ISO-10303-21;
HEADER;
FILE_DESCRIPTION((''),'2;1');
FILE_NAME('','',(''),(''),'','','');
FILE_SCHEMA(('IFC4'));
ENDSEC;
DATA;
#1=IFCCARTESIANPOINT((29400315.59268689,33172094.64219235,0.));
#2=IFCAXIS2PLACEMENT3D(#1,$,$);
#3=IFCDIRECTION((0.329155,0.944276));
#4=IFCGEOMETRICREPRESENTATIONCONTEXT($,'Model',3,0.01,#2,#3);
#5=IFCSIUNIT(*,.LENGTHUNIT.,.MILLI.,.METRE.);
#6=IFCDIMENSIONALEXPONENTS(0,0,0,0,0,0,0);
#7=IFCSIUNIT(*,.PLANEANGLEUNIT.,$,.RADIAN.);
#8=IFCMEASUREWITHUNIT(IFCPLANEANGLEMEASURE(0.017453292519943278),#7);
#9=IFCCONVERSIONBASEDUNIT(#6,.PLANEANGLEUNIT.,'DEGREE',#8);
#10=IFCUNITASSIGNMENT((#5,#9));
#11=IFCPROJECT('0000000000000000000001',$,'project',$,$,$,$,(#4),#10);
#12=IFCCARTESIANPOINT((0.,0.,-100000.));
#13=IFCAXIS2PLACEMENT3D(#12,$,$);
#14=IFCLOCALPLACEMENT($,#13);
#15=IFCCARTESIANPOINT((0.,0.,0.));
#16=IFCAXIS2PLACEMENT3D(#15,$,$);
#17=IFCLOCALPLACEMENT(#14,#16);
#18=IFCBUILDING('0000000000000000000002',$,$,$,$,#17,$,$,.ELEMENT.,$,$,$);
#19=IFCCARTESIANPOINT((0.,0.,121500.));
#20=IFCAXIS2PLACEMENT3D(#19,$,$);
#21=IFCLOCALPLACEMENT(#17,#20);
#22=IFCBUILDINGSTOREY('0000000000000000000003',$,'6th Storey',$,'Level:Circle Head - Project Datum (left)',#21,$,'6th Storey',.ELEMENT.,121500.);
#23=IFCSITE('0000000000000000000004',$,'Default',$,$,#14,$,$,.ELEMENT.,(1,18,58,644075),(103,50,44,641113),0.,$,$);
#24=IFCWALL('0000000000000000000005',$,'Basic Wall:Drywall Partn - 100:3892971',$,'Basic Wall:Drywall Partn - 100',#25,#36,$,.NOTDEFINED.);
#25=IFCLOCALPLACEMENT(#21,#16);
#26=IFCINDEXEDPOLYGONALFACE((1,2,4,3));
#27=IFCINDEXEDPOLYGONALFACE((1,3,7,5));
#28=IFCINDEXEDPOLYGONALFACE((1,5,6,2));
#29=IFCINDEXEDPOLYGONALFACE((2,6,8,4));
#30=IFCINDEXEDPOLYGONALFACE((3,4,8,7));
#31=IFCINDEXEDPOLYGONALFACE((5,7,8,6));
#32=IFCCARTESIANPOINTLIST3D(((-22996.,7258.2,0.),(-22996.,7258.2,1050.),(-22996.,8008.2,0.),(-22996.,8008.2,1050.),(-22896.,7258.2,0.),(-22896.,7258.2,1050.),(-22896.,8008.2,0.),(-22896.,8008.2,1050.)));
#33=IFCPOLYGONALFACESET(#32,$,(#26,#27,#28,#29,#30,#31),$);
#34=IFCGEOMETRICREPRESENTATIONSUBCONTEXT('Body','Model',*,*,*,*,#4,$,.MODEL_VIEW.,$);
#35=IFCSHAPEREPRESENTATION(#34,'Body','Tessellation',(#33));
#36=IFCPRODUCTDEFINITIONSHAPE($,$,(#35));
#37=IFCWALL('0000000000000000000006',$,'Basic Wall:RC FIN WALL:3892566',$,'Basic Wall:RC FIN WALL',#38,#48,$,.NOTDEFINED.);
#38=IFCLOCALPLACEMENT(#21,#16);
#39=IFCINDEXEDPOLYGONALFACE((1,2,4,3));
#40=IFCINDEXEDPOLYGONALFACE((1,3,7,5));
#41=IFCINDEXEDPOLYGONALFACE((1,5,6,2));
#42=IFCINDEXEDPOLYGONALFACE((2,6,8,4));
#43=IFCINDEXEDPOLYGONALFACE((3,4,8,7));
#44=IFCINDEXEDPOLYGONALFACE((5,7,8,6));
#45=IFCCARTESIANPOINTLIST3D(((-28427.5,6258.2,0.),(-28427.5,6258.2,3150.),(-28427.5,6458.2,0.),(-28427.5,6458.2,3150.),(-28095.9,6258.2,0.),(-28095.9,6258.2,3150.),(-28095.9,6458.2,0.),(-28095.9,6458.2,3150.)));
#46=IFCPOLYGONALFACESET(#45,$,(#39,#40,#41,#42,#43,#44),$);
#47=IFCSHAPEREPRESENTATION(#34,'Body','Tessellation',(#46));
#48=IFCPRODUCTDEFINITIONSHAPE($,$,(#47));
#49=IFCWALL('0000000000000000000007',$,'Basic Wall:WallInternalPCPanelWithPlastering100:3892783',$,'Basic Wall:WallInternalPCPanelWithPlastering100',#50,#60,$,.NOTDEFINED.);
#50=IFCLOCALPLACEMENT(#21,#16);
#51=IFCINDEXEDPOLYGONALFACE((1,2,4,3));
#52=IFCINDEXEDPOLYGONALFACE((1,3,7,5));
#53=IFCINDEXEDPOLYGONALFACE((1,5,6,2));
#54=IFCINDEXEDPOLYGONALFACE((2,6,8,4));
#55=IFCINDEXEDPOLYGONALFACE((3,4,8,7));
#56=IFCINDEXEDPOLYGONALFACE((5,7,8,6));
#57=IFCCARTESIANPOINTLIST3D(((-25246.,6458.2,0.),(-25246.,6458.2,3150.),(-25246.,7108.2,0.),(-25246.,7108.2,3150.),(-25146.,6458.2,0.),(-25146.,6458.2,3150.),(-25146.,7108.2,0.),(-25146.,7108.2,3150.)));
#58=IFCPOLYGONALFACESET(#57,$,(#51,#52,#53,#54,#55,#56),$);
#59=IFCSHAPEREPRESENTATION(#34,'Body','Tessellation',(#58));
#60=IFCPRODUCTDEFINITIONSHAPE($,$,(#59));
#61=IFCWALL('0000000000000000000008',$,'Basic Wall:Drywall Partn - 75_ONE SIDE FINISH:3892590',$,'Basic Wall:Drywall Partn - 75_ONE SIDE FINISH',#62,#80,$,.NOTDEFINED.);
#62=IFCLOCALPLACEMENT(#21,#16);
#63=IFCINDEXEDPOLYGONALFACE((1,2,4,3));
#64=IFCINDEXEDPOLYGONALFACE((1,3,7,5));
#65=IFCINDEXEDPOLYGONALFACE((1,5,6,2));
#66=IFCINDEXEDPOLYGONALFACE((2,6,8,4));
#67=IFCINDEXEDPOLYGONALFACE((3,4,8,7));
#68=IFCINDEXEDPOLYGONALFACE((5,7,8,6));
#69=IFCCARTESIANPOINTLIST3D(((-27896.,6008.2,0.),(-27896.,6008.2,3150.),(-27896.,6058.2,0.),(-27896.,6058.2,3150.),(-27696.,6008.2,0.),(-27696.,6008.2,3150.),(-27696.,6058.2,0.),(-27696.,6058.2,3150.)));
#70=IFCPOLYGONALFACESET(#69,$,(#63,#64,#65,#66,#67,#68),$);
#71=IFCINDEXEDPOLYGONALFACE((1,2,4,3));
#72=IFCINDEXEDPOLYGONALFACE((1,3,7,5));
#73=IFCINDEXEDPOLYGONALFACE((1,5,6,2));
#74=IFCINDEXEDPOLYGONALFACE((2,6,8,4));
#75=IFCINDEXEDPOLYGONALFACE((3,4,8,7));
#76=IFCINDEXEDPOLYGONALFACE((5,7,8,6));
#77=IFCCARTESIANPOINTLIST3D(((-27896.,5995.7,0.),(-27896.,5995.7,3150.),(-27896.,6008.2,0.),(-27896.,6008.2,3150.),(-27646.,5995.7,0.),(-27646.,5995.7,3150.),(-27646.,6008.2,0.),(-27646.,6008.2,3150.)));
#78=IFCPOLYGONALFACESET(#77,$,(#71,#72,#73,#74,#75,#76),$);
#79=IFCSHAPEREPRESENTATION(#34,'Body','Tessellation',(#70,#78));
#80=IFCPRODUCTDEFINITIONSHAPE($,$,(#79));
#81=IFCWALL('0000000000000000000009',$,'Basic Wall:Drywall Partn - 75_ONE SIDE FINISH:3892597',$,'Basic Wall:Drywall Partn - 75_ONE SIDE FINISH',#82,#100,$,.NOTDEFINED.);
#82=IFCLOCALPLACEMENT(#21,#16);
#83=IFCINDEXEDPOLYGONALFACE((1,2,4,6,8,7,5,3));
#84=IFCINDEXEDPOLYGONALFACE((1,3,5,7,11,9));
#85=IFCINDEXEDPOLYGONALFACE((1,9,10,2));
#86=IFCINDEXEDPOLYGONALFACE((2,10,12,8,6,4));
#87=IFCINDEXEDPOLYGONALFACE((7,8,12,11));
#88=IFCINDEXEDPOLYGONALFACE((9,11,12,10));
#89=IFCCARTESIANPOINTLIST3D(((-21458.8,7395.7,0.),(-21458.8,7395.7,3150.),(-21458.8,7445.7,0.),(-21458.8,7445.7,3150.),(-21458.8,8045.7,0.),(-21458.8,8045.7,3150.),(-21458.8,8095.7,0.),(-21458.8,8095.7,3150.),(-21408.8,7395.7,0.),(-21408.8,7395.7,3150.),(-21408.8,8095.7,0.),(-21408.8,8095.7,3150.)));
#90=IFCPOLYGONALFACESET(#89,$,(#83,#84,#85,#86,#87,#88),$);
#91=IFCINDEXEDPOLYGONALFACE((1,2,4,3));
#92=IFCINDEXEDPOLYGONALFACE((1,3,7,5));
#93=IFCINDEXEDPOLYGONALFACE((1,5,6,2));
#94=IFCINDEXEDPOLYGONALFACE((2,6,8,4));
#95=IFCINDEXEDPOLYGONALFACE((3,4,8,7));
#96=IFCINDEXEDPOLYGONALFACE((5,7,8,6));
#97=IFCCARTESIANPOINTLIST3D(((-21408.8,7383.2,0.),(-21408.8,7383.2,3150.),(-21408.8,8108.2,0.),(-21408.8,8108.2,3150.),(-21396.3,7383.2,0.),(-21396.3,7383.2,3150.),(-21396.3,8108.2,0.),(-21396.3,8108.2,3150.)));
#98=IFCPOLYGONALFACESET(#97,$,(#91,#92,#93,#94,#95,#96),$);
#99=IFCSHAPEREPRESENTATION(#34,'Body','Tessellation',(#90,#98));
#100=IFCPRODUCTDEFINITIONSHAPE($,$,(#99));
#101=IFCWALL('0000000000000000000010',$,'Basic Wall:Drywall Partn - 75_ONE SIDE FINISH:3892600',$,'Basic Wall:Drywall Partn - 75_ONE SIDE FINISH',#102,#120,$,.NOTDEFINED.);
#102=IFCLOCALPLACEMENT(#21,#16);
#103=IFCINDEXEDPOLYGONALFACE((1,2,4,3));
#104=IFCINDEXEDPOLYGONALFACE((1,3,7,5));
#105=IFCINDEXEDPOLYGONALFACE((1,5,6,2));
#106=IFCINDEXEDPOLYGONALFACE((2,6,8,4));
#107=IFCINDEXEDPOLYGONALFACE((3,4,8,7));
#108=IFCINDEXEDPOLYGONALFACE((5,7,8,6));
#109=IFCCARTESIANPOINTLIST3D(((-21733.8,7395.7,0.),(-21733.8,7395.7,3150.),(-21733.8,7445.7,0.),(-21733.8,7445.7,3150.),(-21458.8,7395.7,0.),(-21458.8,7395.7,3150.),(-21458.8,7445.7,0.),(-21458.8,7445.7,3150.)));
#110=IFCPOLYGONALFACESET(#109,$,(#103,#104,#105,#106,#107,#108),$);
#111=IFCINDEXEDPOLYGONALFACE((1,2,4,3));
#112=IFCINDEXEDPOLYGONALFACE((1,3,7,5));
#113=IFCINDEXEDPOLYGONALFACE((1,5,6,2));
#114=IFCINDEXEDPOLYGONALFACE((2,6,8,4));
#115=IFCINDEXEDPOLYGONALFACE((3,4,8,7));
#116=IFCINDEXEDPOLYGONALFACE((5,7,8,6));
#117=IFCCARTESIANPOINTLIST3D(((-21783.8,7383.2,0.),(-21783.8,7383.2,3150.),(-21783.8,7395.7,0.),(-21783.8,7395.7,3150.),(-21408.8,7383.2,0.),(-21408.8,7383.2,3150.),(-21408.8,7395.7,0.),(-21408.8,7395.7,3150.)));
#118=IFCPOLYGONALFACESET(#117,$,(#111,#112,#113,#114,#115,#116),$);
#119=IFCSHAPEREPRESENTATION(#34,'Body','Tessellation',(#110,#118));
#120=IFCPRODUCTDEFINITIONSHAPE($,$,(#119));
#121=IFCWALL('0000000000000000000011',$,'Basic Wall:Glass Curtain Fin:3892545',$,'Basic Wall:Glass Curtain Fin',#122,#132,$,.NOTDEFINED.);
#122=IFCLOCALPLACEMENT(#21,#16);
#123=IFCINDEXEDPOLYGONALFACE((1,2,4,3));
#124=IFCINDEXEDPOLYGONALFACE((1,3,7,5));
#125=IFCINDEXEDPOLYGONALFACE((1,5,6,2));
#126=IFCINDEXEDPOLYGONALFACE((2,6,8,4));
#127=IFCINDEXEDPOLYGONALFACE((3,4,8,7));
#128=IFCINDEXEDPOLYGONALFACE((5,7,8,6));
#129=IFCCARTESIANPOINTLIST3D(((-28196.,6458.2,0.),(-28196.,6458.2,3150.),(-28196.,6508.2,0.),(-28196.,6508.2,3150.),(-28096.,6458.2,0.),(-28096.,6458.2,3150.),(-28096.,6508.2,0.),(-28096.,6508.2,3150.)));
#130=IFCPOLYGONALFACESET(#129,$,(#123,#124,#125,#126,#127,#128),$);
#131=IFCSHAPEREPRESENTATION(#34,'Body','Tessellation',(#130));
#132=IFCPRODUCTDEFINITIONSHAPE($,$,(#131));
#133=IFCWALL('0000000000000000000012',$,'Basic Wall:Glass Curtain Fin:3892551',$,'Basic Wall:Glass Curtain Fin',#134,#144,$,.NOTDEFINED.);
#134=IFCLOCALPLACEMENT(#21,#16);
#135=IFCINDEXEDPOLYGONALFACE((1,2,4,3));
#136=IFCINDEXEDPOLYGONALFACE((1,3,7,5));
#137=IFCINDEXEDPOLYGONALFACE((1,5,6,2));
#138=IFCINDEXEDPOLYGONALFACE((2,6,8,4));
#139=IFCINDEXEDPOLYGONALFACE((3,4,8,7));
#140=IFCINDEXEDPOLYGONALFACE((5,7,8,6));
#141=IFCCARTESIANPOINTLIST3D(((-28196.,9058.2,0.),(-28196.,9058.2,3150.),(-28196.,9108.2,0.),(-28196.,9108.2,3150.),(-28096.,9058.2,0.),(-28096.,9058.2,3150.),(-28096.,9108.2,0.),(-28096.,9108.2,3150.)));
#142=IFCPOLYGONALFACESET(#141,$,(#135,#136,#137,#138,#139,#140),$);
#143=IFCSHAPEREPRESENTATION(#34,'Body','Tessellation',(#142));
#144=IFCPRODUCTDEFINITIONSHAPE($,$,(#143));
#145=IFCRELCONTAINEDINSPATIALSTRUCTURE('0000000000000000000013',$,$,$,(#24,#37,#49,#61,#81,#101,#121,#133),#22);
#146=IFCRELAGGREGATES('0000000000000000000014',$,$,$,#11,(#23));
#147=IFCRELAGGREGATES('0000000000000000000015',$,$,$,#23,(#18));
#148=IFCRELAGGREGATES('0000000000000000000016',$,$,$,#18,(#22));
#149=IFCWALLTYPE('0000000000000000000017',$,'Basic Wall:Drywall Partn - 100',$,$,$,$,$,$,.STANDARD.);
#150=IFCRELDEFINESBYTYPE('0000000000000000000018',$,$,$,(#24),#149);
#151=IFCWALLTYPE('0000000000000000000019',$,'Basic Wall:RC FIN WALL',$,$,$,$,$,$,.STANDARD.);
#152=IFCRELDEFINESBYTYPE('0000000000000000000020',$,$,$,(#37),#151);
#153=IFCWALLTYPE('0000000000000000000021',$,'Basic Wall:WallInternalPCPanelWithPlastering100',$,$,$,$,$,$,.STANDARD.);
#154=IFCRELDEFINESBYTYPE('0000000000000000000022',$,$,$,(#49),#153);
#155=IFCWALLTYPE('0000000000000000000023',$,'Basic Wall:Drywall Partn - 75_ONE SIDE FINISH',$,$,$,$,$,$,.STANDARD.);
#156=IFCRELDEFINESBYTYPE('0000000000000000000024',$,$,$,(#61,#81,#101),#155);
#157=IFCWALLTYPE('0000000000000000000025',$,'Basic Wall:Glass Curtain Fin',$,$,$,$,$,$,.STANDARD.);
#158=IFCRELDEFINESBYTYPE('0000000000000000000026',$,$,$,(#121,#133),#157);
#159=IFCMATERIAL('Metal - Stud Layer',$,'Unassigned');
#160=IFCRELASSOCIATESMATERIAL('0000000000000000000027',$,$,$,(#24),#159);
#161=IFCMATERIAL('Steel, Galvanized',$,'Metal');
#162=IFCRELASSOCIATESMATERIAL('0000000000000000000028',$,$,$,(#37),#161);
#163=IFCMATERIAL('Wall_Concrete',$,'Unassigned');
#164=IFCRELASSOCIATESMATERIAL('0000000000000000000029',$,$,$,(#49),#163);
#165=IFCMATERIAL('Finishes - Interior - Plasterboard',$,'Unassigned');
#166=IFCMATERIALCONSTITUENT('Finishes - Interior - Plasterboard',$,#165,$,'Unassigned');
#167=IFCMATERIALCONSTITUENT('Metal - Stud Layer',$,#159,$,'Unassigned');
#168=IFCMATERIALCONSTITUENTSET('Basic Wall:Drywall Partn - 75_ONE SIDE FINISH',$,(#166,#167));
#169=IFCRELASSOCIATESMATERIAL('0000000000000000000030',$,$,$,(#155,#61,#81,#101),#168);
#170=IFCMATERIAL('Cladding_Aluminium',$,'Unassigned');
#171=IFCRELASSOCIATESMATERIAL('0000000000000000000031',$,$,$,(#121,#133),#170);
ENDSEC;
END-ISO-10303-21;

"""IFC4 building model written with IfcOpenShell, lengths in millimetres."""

from ifc_helpers import new_model, entity, si_unit, converted_unit, direction, frame, origin, place, context, subcontext, project, spatial, indexed_curve, outline, extrude, material, constituent, constituent_set, type_object, element, save


model = new_model("IFC4")

# Units and contexts
model_context = context("Model", 3, precision=0.01, world=frame((29400315.59268689, 33172094.64219235, 0.0)), true_north=direction((0.329155, 0.944276)))
body_context = subcontext(model_context, "Body", "Model", "MODEL_VIEW")
ifc_project = project(units=[si_unit("LENGTHUNIT", "METRE", prefix="MILLI"), converted_unit("PLANEANGLEUNIT", "DEGREE", entity("IfcPlaneAngleMeasure", 0.017453292519943278), si_unit("PLANEANGLEUNIT", "RADIAN"), dimensions=[0, 0, 0, 0, 0, 0, 0])], contexts=[model_context])

# Site, building, storey
site_placement = place(None, frame((0.0, 0.0, -100000.0)))
site = spatial("IfcSite", under=ifc_project, at=site_placement, Name="Default", CompositionType="ELEMENT", RefLatitude=(1, 18, 58, 644075), RefLongitude=(103, 50, 44, 641113), RefElevation=0.0)
building_placement = place(site_placement, origin())
building = spatial("IfcBuilding", under=site, at=building_placement, CompositionType="ELEMENT")
storey_placement = place(building_placement, frame((0.0, 0.0, 121500.0)))
storey = spatial("IfcBuildingStorey", under=building, at=storey_placement, Name="6th Storey", ObjectType="Level:Circle Head - Project Datum (left)", LongName="6th Storey", CompositionType="ELEMENT", Elevation=121500.0)

# Walls
ifc_material_1 = material(Name="Metal - Stud Layer", Category="Unassigned")
wall_type_1 = type_object("IfcWallType", Name="Basic Wall:Drywall Partn - 100", PredefinedType="STANDARD")
wall_1_placement = place(storey_placement, frame((-22946.0, 8008.2, 0.0), z_axis=(0.0, 0.0, 1.0), x_axis=(0.0, -1.0, 0.0)))
element("IfcWall", 1, at=wall_1_placement, inside=storey, type_object=wall_type_1, material=ifc_material_1, Name="Basic Wall:Drywall Partn - 100:3892971", ObjectType="Basic Wall:Drywall Partn - 100", PredefinedType="NOTDEFINED", context=body_context, shape_type="SweptSolid", body=[
    extrude(outline(indexed_curve([(750.0, 50.0), (0.0, 50.0), (0.0, -50.0), (750.0, -50.0), (750.0, 50.0)], self_intersect=False)), origin(), (0.0, 0.0, 1.0), 1050.0),
])
ifc_material_2 = material(Name="Steel, Galvanized", Category="Metal")
wall_type_2 = type_object("IfcWallType", Name="Basic Wall:RC FIN WALL", PredefinedType="STANDARD")
wall_2_placement = place(storey_placement, frame((-28095.9, 6358.2, 0.0), z_axis=(0.0, 0.0, 1.0), x_axis=(-1.0, 0.0, 0.0)))
element("IfcWall", 2, at=wall_2_placement, inside=storey, type_object=wall_type_2, material=ifc_material_2, Name="Basic Wall:RC FIN WALL:3892566", ObjectType="Basic Wall:RC FIN WALL", PredefinedType="NOTDEFINED", context=body_context, shape_type="SweptSolid", body=[
    extrude(outline(indexed_curve([(331.6, 100.0), (0.0, 100.0), (0.0, -100.0), (331.6, -100.0), (331.6, 100.0)], self_intersect=False)), origin(), (0.0, 0.0, 1.0), 3150.0),
])
ifc_material_3 = material(Name="Wall_Concrete", Category="Unassigned")
wall_type_3 = type_object("IfcWallType", Name="Basic Wall:WallInternalPCPanelWithPlastering100", PredefinedType="STANDARD")
wall_3_placement = place(storey_placement, frame((-25196.0, 6458.2, 0.0), z_axis=(0.0, 0.0, 1.0), x_axis=(0.0, 1.0, 0.0)))
element("IfcWall", 3, at=wall_3_placement, inside=storey, type_object=wall_type_3, material=ifc_material_3, Name="Basic Wall:WallInternalPCPanelWithPlastering100:3892783", ObjectType="Basic Wall:WallInternalPCPanelWithPlastering100", PredefinedType="NOTDEFINED", context=body_context, shape_type="SweptSolid", body=[
    extrude(outline(indexed_curve([(650.0, 50.0), (0.0, 50.0), (0.0, -50.0), (650.0, -50.0), (650.0, 50.0)], self_intersect=False)), origin(), (0.0, 0.0, 1.0), 3150.0),
])
ifc_material_4 = material(Name="Finishes - Interior - Plasterboard", Category="Unassigned")
ifc_constituent_1 = constituent(ifc_material_4, Name="Finishes - Interior - Plasterboard", Category="Unassigned")
ifc_constituent_2 = constituent(ifc_material_1, Name="Metal - Stud Layer", Category="Unassigned")
ifc_constituent_set = constituent_set(constituents=[ifc_constituent_1, ifc_constituent_2], Name="Basic Wall:Drywall Partn - 75_ONE SIDE FINISH")
wall_type_4 = type_object("IfcWallType", Name="Basic Wall:Drywall Partn - 75_ONE SIDE FINISH", PredefinedType="STANDARD", material=ifc_constituent_set)
wall_4_placement = place(storey_placement, frame((-27696.0, 6027.0, 0.0), z_axis=(0.0, 0.0, 1.0), x_axis=(-1.0, 0.0, 0.0)))
element("IfcWall", 4, at=wall_4_placement, inside=storey, type_object=wall_type_4, material=ifc_constituent_set, Name="Basic Wall:Drywall Partn - 75_ONE SIDE FINISH:3892590", ObjectType="Basic Wall:Drywall Partn - 75_ONE SIDE FINISH", PredefinedType="NOTDEFINED", context=body_context, shape_type="SweptSolid", body=[
    extrude(outline(indexed_curve([(-25.0, -100.0), (25.0, -100.0), (25.0, 100.0), (-25.0, 100.0), (-25.0, -100.0)], self_intersect=False)), frame((100.0, -6.2, 0.0), z_axis=(0.0, 0.0, 1.0), x_axis=(0.0, 1.0, 0.0)), (0.0, 0.0, 1.0), 3150.0),
    extrude(outline(indexed_curve([(-6.3, -125.0), (6.2, -125.0), (6.2, 125.0), (-6.3, 125.0), (-6.3, -125.0)], self_intersect=False)), frame((75.0, 25.0, 0.0), z_axis=(0.0, 0.0, 1.0), x_axis=(0.0, 1.0, 0.0)), (0.0, 0.0, 1.0), 3150.0),
])
wall_5_placement = place(storey_placement, frame((-21427.6, 7383.2, 0.0), z_axis=(0.0, 0.0, 1.0), x_axis=(0.0, 1.0, 0.0)))
element("IfcWall", 5, at=wall_5_placement, inside=storey, type_object=wall_type_4, material=ifc_constituent_set, Name="Basic Wall:Drywall Partn - 75_ONE SIDE FINISH:3892597", ObjectType="Basic Wall:Drywall Partn - 75_ONE SIDE FINISH", PredefinedType="NOTDEFINED", context=body_context, shape_type="SweptSolid", body=[
    extrude(outline(indexed_curve([(-300.0, -16.7), (300.0, -16.7), (350.0, -16.7), (350.0, 33.3), (-350.0, 33.3), (-350.0, -16.7), (-300.0, -16.7)], self_intersect=False)), frame((362.5, 14.6, 0.0), z_axis=(0.0, 0.0, 1.0), x_axis=(-1.0, 0.0, 0.0)), (0.0, 0.0, 1.0), 3150.0),
    extrude(outline(indexed_curve([(-6.2, -362.5), (6.2, -362.5), (6.2, 362.5), (-6.3, 362.5), (-6.2, -362.5)], self_intersect=False)), frame((362.5, -25.0, 0.0), z_axis=(0.0, 0.0, 1.0), x_axis=(0.0, 1.0, 0.0)), (0.0, 0.0, 1.0), 3150.0),
])

# Walls
wall_6_placement = place(storey_placement, frame((-21458.8, 7414.5, 0.0), z_axis=(0.0, 0.0, 1.0), x_axis=(-1.0, 0.0, 0.0)))
element("IfcWall", 6, at=wall_6_placement, inside=storey, type_object=wall_type_4, material=ifc_constituent_set, Name="Basic Wall:Drywall Partn - 75_ONE SIDE FINISH:3892600", ObjectType="Basic Wall:Drywall Partn - 75_ONE SIDE FINISH", PredefinedType="NOTDEFINED", context=body_context, shape_type="SweptSolid", body=[
    extrude(outline(indexed_curve([(-25.0, -137.5), (25.0, -137.5), (25.0, 137.5), (-25.0, 137.5), (-25.0, -137.5)], self_intersect=False)), frame((137.5, -6.2, 0.0), z_axis=(0.0, 0.0, 1.0), x_axis=(0.0, 1.0, 0.0)), (0.0, 0.0, 1.0), 3150.0),
    extrude(outline(indexed_curve([(-6.2, -187.5), (6.3, -187.5), (6.2, 187.5), (-6.3, 187.5), (-6.2, -187.5)], self_intersect=False)), frame((137.5, 25.0, 0.0), z_axis=(0.0, 0.0, 1.0), x_axis=(0.0, -1.0, 0.0)), (0.0, 0.0, 1.0), 3150.0),
])
ifc_material_5 = material(Name="Cladding_Aluminium", Category="Unassigned")
wall_type_5 = type_object("IfcWallType", Name="Basic Wall:Glass Curtain Fin", PredefinedType="STANDARD")
for number, where, z_axis, x_axis, name in (
    (7, (-28096.0, 6483.2, 0.0), (0.0, 0.0, 1.0), (-1.0, 0.0, 0.0), "Basic Wall:Glass Curtain Fin:3892545"),
    (8, (-28096.0, 9083.2, 0.0), (0.0, 0.0, 1.0), (-1.0, 0.0, 0.0), "Basic Wall:Glass Curtain Fin:3892551"),
):
    element("IfcWall", number, at=place(storey_placement, frame(where, z_axis=z_axis, x_axis=x_axis)), inside=storey, type_object=wall_type_5, material=ifc_material_5, Name=name, ObjectType="Basic Wall:Glass Curtain Fin", PredefinedType="NOTDEFINED", context=body_context, shape_type="SweptSolid", body=[
        extrude(outline(indexed_curve([(100.0, 25.0), (0.0, 25.0), (0.0, -25.0), (100.0, -25.0), (100.0, 25.0)], self_intersect=False)), origin(), (0.0, 0.0, 1.0), 3150.0),
    ])

save(model, "model.ifc")
